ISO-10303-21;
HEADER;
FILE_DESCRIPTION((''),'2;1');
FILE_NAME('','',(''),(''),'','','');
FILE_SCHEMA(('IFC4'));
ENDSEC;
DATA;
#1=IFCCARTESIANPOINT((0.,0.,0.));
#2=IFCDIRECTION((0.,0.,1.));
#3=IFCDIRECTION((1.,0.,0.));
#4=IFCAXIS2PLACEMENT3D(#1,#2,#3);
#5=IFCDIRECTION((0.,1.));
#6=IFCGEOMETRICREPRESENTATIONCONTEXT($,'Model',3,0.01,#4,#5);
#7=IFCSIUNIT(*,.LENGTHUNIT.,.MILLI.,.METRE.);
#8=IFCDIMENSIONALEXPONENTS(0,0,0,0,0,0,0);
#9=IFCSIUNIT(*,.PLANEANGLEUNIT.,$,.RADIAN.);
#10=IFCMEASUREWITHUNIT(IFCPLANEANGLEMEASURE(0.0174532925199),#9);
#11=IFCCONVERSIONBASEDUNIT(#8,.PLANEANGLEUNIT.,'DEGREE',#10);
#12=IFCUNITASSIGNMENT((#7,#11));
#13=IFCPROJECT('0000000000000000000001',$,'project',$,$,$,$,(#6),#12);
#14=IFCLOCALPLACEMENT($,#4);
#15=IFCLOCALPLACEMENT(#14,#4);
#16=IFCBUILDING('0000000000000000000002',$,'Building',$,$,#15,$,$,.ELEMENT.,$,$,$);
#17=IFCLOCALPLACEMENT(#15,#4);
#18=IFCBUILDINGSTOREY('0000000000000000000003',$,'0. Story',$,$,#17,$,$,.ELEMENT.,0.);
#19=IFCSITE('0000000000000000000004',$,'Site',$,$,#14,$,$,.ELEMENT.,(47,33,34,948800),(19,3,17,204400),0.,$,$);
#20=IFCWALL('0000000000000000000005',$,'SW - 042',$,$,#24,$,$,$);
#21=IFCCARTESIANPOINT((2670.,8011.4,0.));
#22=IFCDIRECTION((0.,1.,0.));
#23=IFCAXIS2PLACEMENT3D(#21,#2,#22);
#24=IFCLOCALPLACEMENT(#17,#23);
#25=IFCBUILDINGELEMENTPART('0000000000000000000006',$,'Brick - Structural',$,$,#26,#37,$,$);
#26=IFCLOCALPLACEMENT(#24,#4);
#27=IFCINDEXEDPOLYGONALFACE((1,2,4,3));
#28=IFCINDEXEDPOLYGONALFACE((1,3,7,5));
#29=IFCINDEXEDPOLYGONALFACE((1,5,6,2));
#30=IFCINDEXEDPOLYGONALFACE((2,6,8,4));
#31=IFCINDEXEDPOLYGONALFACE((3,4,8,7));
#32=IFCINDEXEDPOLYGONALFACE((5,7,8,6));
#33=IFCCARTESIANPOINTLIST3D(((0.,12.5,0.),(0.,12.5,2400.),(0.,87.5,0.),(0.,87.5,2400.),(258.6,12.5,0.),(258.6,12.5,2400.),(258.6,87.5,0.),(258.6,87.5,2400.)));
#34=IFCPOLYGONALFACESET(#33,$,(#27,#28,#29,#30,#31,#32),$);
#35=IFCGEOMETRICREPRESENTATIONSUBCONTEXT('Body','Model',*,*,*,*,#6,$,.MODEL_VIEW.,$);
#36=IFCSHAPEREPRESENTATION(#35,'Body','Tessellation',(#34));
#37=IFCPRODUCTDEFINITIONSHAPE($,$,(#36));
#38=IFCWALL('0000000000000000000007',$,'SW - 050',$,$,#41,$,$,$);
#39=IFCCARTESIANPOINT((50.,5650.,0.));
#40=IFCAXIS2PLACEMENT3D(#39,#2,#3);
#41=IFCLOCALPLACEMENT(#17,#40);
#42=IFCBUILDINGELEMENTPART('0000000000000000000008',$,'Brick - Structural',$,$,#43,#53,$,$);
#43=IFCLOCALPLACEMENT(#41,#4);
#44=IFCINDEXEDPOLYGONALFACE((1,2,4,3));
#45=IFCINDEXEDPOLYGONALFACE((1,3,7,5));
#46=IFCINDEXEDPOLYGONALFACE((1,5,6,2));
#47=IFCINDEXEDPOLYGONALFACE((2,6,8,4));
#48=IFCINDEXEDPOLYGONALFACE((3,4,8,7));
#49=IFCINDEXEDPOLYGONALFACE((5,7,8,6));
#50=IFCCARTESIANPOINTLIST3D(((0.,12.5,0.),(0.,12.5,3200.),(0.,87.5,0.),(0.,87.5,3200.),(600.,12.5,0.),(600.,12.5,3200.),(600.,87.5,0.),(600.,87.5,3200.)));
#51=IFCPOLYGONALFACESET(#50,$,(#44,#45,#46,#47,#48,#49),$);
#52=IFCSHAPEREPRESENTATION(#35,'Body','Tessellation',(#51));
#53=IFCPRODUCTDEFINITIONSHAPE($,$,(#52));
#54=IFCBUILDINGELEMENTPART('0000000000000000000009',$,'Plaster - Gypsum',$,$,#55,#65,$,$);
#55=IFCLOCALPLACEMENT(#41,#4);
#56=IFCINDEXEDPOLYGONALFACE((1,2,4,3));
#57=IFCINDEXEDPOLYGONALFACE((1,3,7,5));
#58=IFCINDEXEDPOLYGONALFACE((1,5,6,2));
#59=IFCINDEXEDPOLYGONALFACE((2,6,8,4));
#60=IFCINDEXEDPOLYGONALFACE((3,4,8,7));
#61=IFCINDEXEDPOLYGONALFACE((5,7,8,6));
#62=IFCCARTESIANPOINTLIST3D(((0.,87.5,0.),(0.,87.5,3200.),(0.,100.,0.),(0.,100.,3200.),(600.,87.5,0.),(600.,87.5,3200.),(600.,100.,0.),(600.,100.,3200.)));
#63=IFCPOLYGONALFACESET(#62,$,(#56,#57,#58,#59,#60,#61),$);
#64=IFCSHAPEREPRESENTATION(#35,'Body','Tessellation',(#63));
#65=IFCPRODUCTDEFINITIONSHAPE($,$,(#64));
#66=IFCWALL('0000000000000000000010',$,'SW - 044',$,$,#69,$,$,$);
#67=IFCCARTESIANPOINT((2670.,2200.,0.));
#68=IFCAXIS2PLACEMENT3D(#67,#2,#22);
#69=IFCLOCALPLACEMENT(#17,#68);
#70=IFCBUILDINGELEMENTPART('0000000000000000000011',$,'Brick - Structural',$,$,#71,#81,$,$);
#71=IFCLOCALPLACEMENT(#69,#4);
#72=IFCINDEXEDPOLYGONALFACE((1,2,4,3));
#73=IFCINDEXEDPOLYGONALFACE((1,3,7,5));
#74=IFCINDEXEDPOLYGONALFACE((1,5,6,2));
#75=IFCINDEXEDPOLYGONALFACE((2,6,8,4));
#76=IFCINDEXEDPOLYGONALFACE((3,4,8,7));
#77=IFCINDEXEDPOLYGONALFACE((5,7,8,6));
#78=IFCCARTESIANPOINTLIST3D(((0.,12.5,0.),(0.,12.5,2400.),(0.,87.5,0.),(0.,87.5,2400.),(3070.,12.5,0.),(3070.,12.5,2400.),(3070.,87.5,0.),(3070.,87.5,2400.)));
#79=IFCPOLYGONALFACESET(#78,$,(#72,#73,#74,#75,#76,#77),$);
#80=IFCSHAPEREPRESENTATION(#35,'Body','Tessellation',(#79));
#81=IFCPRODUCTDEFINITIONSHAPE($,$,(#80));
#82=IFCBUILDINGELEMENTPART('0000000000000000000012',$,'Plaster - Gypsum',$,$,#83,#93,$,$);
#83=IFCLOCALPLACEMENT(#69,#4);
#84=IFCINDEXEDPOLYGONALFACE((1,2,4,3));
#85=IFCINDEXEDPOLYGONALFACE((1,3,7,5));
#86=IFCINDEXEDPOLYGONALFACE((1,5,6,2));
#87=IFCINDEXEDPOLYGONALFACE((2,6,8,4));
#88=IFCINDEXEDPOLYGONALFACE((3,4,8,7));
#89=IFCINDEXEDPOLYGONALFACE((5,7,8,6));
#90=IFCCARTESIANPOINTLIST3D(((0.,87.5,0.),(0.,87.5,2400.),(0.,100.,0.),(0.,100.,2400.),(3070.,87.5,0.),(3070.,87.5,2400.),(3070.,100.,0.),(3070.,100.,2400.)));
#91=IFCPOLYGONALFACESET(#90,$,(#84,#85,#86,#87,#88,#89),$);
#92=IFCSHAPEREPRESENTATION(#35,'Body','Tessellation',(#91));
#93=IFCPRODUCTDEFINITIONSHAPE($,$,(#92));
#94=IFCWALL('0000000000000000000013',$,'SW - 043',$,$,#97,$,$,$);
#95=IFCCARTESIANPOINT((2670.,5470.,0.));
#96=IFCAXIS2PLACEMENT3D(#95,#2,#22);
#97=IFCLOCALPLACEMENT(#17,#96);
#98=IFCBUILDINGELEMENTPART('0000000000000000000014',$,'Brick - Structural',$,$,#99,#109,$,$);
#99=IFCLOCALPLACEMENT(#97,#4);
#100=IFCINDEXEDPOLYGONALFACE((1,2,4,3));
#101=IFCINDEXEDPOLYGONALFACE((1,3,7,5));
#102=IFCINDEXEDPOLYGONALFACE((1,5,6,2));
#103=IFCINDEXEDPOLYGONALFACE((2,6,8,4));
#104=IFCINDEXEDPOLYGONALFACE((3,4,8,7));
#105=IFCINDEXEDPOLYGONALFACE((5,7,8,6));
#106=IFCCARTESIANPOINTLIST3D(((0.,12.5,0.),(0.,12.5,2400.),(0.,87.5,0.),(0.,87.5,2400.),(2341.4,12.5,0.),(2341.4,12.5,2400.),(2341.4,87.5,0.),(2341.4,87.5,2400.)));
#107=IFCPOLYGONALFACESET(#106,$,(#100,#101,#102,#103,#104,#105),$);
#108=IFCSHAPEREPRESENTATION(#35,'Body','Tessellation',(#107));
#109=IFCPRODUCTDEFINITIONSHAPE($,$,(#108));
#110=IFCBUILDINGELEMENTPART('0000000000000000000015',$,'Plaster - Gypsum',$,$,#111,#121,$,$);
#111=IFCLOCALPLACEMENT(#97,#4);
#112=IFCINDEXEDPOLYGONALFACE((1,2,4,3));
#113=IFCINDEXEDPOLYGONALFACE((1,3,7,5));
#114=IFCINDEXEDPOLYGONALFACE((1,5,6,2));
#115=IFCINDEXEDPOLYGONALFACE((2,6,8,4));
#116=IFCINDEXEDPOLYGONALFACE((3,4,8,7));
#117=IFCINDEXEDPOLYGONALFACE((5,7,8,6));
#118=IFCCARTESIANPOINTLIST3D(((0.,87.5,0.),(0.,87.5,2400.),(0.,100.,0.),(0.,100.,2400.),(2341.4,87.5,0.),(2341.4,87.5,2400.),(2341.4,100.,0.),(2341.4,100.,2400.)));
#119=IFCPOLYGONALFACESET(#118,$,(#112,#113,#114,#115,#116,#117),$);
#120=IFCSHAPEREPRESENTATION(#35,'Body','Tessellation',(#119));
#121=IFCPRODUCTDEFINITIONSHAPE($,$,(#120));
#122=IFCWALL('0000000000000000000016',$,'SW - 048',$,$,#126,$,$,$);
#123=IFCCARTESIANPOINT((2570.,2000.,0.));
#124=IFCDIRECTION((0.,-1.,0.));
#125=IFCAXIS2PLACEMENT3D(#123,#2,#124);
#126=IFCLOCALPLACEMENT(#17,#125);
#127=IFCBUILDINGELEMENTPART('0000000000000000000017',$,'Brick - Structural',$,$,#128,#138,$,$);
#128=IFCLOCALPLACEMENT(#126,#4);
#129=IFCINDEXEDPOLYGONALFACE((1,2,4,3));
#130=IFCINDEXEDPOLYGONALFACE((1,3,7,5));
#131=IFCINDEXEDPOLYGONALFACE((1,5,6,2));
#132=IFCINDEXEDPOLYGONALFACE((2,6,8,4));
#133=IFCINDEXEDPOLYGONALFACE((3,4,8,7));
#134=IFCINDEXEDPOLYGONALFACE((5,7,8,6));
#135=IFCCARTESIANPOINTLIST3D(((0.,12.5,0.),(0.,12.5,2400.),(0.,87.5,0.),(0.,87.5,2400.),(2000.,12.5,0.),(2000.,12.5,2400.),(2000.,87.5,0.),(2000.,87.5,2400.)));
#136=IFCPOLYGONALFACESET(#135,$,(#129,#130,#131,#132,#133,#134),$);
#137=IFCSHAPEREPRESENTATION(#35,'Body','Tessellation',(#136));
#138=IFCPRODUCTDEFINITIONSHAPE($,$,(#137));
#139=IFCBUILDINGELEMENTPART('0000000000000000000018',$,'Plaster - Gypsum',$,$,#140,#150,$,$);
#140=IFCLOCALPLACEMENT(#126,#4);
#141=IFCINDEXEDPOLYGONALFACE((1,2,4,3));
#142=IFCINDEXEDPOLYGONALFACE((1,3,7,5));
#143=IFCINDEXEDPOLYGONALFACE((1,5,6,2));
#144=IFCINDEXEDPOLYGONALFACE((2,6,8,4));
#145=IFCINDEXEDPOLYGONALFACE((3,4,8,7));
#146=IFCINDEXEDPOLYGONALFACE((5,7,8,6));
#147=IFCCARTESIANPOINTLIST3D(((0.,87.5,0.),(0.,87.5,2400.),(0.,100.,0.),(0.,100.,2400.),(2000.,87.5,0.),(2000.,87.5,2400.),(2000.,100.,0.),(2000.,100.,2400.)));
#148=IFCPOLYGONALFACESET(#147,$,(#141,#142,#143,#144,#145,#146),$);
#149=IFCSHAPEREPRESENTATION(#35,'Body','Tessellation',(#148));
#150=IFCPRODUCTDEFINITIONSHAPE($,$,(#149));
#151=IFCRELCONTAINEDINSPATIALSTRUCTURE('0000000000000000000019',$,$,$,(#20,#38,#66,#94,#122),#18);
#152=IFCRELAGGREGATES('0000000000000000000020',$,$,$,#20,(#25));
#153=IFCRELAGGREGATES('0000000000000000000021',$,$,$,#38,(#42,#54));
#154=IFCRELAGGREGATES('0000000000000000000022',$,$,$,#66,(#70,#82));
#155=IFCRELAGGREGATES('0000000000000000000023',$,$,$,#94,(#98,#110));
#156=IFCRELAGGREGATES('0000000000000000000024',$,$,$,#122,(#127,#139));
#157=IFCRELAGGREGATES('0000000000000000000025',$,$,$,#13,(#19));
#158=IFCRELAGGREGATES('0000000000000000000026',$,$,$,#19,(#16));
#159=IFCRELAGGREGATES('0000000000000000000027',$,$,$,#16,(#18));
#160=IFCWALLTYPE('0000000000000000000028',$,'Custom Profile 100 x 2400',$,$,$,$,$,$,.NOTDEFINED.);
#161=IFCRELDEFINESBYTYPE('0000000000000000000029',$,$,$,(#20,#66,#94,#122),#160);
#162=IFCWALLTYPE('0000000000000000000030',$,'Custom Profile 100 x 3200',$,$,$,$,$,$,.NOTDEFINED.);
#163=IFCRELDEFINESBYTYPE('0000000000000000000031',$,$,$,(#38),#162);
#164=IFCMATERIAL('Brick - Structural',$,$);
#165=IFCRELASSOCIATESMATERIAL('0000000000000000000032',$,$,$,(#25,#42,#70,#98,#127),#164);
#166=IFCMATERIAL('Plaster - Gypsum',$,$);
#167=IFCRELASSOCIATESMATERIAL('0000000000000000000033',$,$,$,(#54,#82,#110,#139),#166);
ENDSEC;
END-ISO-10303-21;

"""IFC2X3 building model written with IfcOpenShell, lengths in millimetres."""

from ifc_helpers import new_model, entity, si_unit, converted_unit, direction, frame, origin_with_axes, place, context, subcontext, project, spatial, polyline, outline, extrude, material, type_object, element, aggregate, save


model = new_model("IFC2X3")

# Units and contexts
model_context = context("Model", 3, precision=0.01, world=origin_with_axes(), true_north=direction((0.0, 1.0)))
body_context = subcontext(model_context, "Body", "Model", "MODEL_VIEW")
ifc_project = project(units=[si_unit("LENGTHUNIT", "METRE", prefix="MILLI"), converted_unit("PLANEANGLEUNIT", "DEGREE", entity("IfcPlaneAngleMeasure", 0.0174532925199), si_unit("PLANEANGLEUNIT", "RADIAN"), dimensions=[0, 0, 0, 0, 0, 0, 0])], contexts=[model_context])

# Site, building, storey
site_placement = place(None, origin_with_axes())
site = spatial("IfcSite", under=ifc_project, at=site_placement, Name="Site", CompositionType="ELEMENT", RefLatitude=(47, 33, 34, 948800), RefLongitude=(19, 3, 17, 204400), RefElevation=0.0)
building_placement = place(site_placement, origin_with_axes())
building = spatial("IfcBuilding", under=site, at=building_placement, Name="Building", CompositionType="ELEMENT")
storey_placement = place(building_placement, origin_with_axes())
storey = spatial("IfcBuildingStorey", under=building, at=storey_placement, Name="0. Story", CompositionType="ELEMENT", Elevation=0.0)

# Walls, building element parts
wall_type_1 = type_object("IfcWallType", Name="Custom Profile 100 x 2400", PredefinedType="NOTDEFINED")
wall_1_placement = place(storey_placement, frame((2670.0, 8011.4, 0.0), z_axis=(0.0, 0.0, 1.0), x_axis=(0.0, 1.0, 0.0)))
wall_1 = element("IfcWall", 1, at=wall_1_placement, inside=storey, type_object=wall_type_1, Name="SW - 042")
ifc_material_1 = material(Name="Plaster - Gypsum")
ifc_material_2 = material(Name="Brick - Structural")
building_element_part_1_placement = place(wall_1_placement, origin_with_axes())
building_element_part_1 = element("IfcBuildingElementPart", 2, at=building_element_part_1_placement, material=ifc_material_2, Name="Brick - Structural", context=body_context, shape_type="SweptSolid", body=[
    extrude(outline(polyline([(-87.5, 0.0), (-12.5, 0.0), (-12.5, 2400.0), (-87.5, 2400.0), (-87.5, 0.0)])), frame((0.0, 0.0, 0.0), z_axis=(-1.0, 0.0, 0.0), x_axis=(0.0, -1.0, 0.0)), (0.0, 0.0, -1.0), 258.6),
])
aggregate(wall_1, [building_element_part_1])
wall_type_2 = type_object("IfcWallType", Name="Custom Profile 100 x 3200", PredefinedType="NOTDEFINED")
wall_2_placement = place(storey_placement, frame((50.0, 5650.0, 0.0), z_axis=(0.0, 0.0, 1.0), x_axis=(1.0, 0.0, 0.0)))
wall_2 = element("IfcWall", 3, at=wall_2_placement, inside=storey, type_object=wall_type_2, Name="SW - 050")
building_element_part_2_placement = place(wall_2_placement, origin_with_axes())
building_element_part_2 = element("IfcBuildingElementPart", 4, at=building_element_part_2_placement, material=ifc_material_2, Name="Brick - Structural", context=body_context, shape_type="SweptSolid", body=[
    extrude(outline(polyline([(-87.5, 0.0), (-12.5, 0.0), (-12.5, 3200.0), (-87.5, 3200.0), (-87.5, 0.0)])), frame((0.0, 0.0, 0.0), z_axis=(-1.0, 0.0, 0.0), x_axis=(0.0, -1.0, 0.0)), (0.0, 0.0, -1.0), 600.0),
])
building_element_part_3_placement = place(wall_2_placement, origin_with_axes())
building_element_part_3 = element("IfcBuildingElementPart", 5, at=building_element_part_3_placement, material=ifc_material_1, Name="Plaster - Gypsum", context=body_context, shape_type="SweptSolid", body=[
    extrude(outline(polyline([(-100.0, 3200.0), (-100.0, 0.0), (-87.5, 0.0), (-87.5, 3200.0), (-100.0, 3200.0)])), frame((0.0, 0.0, 0.0), z_axis=(-1.0, 0.0, 0.0), x_axis=(0.0, -1.0, 0.0)), (0.0, 0.0, -1.0), 600.0),
])
aggregate(wall_2, [building_element_part_2, building_element_part_3])
wall_3_placement = place(storey_placement, frame((2670.0, 2200.0, 0.0), z_axis=(0.0, 0.0, 1.0), x_axis=(0.0, 1.0, 0.0)))
wall_3 = element("IfcWall", 6, at=wall_3_placement, inside=storey, type_object=wall_type_1, Name="SW - 044")
building_element_part_4_placement = place(wall_3_placement, origin_with_axes())
building_element_part_4 = element("IfcBuildingElementPart", 7, at=building_element_part_4_placement, material=ifc_material_2, Name="Brick - Structural", context=body_context, shape_type="SweptSolid", body=[
    extrude(outline(polyline([(-87.5, 0.0), (-12.5, 0.0), (-12.5, 2400.0), (-87.5, 2400.0), (-87.5, 0.0)])), frame((0.0, 0.0, 0.0), z_axis=(-1.0, 0.0, 0.0), x_axis=(0.0, -1.0, 0.0)), (0.0, 0.0, -1.0), 3070.0),
])
building_element_part_5_placement = place(wall_3_placement, origin_with_axes())
building_element_part_5 = element("IfcBuildingElementPart", 8, at=building_element_part_5_placement, material=ifc_material_1, Name="Plaster - Gypsum", context=body_context, shape_type="SweptSolid", body=[
    extrude(outline(polyline([(-100.0, 2400.0), (-100.0, 0.0), (-87.5, 0.0), (-87.5, 2400.0), (-100.0, 2400.0)])), frame((0.0, 0.0, 0.0), z_axis=(-1.0, 0.0, 0.0), x_axis=(0.0, -1.0, 0.0)), (0.0, 0.0, -1.0), 3070.0),
])
aggregate(wall_3, [building_element_part_4, building_element_part_5])
wall_4_placement = place(storey_placement, frame((2670.0, 5470.0, 0.0), z_axis=(0.0, 0.0, 1.0), x_axis=(0.0, 1.0, 0.0)))
wall_4 = element("IfcWall", 9, at=wall_4_placement, inside=storey, type_object=wall_type_1, Name="SW - 043")
building_element_part_6_placement = place(wall_4_placement, origin_with_axes())
building_element_part_6 = element("IfcBuildingElementPart", 10, at=building_element_part_6_placement, material=ifc_material_2, Name="Brick - Structural", context=body_context, shape_type="SweptSolid", body=[
    extrude(outline(polyline([(-87.5, 0.0), (-12.5, 0.0), (-12.5, 2400.0), (-87.5, 2400.0), (-87.5, 0.0)])), frame((0.0, 0.0, 0.0), z_axis=(-1.0, 0.0, 0.0), x_axis=(0.0, -1.0, 0.0)), (0.0, 0.0, -1.0), 2341.4),
])
building_element_part_7_placement = place(wall_4_placement, origin_with_axes())
building_element_part_7 = element("IfcBuildingElementPart", 11, at=building_element_part_7_placement, material=ifc_material_1, Name="Plaster - Gypsum", context=body_context, shape_type="SweptSolid", body=[
    extrude(outline(polyline([(-100.0, 2400.0), (-100.0, 0.0), (-87.5, 0.0), (-87.5, 2400.0), (-100.0, 2400.0)])), frame((0.0, 0.0, 0.0), z_axis=(-1.0, 0.0, 0.0), x_axis=(0.0, -1.0, 0.0)), (0.0, 0.0, -1.0), 2341.4),
])
aggregate(wall_4, [building_element_part_6, building_element_part_7])
wall_5_placement = place(storey_placement, frame((2570.0, 2000.0, 0.0), z_axis=(0.0, 0.0, 1.0), x_axis=(0.0, -1.0, 0.0)))
wall_5 = element("IfcWall", 12, at=wall_5_placement, inside=storey, type_object=wall_type_1, Name="SW - 048")
building_element_part_8_placement = place(wall_5_placement, origin_with_axes())
building_element_part_8 = element("IfcBuildingElementPart", 13, at=building_element_part_8_placement, material=ifc_material_2, Name="Brick - Structural", context=body_context, shape_type="SweptSolid", body=[
    extrude(outline(polyline([(-87.5, 0.0), (-12.5, 0.0), (-12.5, 2400.0), (-87.5, 2400.0), (-87.5, 0.0)])), frame((0.0, 0.0, 0.0), z_axis=(-1.0, 0.0, 0.0), x_axis=(0.0, -1.0, 0.0)), (0.0, 0.0, -1.0), 2000.0),
])
building_element_part_9_placement = place(wall_5_placement, origin_with_axes())
building_element_part_9 = element("IfcBuildingElementPart", 14, at=building_element_part_9_placement, material=ifc_material_1, Name="Plaster - Gypsum", context=body_context, shape_type="SweptSolid", body=[
    extrude(outline(polyline([(-100.0, 2400.0), (-100.0, 0.0), (-87.5, 0.0), (-87.5, 2400.0), (-100.0, 2400.0)])), frame((0.0, 0.0, 0.0), z_axis=(-1.0, 0.0, 0.0), x_axis=(0.0, -1.0, 0.0)), (0.0, 0.0, -1.0), 2000.0),
])
aggregate(wall_5, [building_element_part_8, building_element_part_9])

save(model, "model.ifc")
